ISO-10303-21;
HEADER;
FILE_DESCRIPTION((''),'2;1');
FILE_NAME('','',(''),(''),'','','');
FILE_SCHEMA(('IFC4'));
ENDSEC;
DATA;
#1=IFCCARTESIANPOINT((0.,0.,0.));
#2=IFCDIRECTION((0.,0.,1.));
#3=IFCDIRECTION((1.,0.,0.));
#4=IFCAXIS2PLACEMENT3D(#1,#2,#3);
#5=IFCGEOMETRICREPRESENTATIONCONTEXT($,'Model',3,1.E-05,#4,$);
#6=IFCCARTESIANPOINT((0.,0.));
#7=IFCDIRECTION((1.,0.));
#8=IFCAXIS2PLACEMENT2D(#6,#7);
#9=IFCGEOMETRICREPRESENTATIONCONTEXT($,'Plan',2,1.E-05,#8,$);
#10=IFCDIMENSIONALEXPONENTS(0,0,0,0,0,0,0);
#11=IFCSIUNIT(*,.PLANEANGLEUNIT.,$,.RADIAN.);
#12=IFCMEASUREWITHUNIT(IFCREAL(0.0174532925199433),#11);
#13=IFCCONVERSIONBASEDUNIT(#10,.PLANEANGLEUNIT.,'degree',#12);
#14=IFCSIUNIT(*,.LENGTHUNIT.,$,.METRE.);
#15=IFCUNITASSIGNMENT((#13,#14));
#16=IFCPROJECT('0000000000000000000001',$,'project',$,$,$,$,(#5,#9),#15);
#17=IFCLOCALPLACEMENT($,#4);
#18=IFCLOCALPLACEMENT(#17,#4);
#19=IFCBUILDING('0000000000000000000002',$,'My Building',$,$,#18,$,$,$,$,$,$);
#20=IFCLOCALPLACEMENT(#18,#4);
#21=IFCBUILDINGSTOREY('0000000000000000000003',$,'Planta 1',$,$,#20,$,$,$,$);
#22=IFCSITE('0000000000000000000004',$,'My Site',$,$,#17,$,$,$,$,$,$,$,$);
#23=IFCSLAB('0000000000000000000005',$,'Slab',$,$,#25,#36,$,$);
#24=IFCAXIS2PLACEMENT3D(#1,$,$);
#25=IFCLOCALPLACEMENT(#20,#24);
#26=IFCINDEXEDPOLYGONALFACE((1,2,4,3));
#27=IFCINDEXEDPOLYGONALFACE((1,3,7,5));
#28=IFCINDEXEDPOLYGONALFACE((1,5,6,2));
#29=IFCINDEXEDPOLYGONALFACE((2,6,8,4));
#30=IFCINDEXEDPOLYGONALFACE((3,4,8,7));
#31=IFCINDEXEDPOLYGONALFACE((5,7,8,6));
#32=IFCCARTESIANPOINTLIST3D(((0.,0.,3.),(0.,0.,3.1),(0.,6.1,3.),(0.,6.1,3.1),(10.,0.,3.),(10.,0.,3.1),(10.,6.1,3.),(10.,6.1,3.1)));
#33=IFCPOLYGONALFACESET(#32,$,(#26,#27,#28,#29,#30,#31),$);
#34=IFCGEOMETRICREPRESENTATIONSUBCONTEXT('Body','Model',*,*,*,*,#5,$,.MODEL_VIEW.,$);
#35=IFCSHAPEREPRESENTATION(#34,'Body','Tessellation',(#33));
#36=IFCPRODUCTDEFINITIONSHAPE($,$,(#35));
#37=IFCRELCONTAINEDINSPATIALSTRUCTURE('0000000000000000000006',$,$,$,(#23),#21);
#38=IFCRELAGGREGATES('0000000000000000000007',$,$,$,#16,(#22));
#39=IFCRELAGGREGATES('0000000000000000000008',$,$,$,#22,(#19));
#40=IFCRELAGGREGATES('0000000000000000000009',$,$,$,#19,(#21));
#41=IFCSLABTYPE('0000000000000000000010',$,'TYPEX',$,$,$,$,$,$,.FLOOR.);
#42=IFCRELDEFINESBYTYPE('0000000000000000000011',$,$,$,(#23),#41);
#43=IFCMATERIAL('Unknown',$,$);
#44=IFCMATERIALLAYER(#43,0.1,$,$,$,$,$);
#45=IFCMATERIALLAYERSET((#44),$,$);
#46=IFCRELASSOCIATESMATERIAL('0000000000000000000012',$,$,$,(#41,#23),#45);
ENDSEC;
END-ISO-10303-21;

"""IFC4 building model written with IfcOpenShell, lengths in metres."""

from ifc_helpers import new_model, entity, si_unit, converted_unit, frame, origin_with_axes, origin_2d_with_axis, place, context, subcontext, project, spatial, line, indexed_curve, outline, extrude, material, layer, layer_set, layer_usage, type_object, element, save


model = new_model("IFC4")

# Units and contexts
model_context = context("Model", 3, precision=1e-05, world=origin_with_axes())
plan_context = context("Plan", 2, precision=1e-05, world=origin_2d_with_axis())
body_context = subcontext(model_context, "Body", "Model", "MODEL_VIEW")
ifc_project = project(units=[converted_unit("PLANEANGLEUNIT", "degree", entity("IfcReal", 0.0174532925199433), si_unit("PLANEANGLEUNIT", "RADIAN"), dimensions=[0, 0, 0, 0, 0, 0, 0]), si_unit("LENGTHUNIT", "METRE")], contexts=[model_context, plan_context])

# Site, building, storey
site_placement = place(None, origin_with_axes())
site = spatial("IfcSite", under=ifc_project, at=site_placement, Name="My Site")
building_placement = place(site_placement, origin_with_axes())
building = spatial("IfcBuilding", under=site, at=building_placement, Name="My Building")
storey_placement = place(building_placement, origin_with_axes())
storey = spatial("IfcBuildingStorey", under=building, at=storey_placement, Name="Planta 1")

# Slab
ifc_material = material(Name="Unknown")
ifc_layer = layer(ifc_material, 0.1)
ifc_layer_set = layer_set([ifc_layer])
ifc_layer_usage = layer_usage(ifc_layer_set, "AXIS3", "POSITIVE", 0.0)
slab_type = type_object("IfcSlabType", Name="TYPEX", PredefinedType="FLOOR", material=ifc_layer_set)
slab_placement = place(storey_placement, frame((0.0, 0.0, 3.0), z_axis=(0.0, 0.0, 1.0), x_axis=(1.0, 0.0, 0.0)))
element("IfcSlab", 1, at=slab_placement, inside=storey, type_object=slab_type, material=ifc_layer_usage, Name="Slab", context=body_context, shape_type="SweptSolid", body=[
    extrude(outline(indexed_curve([(0.0, 0.0), (10.0, 0.0), (10.0, 6.1), (0.0, 6.1)], segments=[line(3, 2), line(2, 1), line(1, 4), line(4, 3)], self_intersect=False)), None, (0.0, 0.0, 1.0), 0.1),
])

save(model, "model.ifc")
